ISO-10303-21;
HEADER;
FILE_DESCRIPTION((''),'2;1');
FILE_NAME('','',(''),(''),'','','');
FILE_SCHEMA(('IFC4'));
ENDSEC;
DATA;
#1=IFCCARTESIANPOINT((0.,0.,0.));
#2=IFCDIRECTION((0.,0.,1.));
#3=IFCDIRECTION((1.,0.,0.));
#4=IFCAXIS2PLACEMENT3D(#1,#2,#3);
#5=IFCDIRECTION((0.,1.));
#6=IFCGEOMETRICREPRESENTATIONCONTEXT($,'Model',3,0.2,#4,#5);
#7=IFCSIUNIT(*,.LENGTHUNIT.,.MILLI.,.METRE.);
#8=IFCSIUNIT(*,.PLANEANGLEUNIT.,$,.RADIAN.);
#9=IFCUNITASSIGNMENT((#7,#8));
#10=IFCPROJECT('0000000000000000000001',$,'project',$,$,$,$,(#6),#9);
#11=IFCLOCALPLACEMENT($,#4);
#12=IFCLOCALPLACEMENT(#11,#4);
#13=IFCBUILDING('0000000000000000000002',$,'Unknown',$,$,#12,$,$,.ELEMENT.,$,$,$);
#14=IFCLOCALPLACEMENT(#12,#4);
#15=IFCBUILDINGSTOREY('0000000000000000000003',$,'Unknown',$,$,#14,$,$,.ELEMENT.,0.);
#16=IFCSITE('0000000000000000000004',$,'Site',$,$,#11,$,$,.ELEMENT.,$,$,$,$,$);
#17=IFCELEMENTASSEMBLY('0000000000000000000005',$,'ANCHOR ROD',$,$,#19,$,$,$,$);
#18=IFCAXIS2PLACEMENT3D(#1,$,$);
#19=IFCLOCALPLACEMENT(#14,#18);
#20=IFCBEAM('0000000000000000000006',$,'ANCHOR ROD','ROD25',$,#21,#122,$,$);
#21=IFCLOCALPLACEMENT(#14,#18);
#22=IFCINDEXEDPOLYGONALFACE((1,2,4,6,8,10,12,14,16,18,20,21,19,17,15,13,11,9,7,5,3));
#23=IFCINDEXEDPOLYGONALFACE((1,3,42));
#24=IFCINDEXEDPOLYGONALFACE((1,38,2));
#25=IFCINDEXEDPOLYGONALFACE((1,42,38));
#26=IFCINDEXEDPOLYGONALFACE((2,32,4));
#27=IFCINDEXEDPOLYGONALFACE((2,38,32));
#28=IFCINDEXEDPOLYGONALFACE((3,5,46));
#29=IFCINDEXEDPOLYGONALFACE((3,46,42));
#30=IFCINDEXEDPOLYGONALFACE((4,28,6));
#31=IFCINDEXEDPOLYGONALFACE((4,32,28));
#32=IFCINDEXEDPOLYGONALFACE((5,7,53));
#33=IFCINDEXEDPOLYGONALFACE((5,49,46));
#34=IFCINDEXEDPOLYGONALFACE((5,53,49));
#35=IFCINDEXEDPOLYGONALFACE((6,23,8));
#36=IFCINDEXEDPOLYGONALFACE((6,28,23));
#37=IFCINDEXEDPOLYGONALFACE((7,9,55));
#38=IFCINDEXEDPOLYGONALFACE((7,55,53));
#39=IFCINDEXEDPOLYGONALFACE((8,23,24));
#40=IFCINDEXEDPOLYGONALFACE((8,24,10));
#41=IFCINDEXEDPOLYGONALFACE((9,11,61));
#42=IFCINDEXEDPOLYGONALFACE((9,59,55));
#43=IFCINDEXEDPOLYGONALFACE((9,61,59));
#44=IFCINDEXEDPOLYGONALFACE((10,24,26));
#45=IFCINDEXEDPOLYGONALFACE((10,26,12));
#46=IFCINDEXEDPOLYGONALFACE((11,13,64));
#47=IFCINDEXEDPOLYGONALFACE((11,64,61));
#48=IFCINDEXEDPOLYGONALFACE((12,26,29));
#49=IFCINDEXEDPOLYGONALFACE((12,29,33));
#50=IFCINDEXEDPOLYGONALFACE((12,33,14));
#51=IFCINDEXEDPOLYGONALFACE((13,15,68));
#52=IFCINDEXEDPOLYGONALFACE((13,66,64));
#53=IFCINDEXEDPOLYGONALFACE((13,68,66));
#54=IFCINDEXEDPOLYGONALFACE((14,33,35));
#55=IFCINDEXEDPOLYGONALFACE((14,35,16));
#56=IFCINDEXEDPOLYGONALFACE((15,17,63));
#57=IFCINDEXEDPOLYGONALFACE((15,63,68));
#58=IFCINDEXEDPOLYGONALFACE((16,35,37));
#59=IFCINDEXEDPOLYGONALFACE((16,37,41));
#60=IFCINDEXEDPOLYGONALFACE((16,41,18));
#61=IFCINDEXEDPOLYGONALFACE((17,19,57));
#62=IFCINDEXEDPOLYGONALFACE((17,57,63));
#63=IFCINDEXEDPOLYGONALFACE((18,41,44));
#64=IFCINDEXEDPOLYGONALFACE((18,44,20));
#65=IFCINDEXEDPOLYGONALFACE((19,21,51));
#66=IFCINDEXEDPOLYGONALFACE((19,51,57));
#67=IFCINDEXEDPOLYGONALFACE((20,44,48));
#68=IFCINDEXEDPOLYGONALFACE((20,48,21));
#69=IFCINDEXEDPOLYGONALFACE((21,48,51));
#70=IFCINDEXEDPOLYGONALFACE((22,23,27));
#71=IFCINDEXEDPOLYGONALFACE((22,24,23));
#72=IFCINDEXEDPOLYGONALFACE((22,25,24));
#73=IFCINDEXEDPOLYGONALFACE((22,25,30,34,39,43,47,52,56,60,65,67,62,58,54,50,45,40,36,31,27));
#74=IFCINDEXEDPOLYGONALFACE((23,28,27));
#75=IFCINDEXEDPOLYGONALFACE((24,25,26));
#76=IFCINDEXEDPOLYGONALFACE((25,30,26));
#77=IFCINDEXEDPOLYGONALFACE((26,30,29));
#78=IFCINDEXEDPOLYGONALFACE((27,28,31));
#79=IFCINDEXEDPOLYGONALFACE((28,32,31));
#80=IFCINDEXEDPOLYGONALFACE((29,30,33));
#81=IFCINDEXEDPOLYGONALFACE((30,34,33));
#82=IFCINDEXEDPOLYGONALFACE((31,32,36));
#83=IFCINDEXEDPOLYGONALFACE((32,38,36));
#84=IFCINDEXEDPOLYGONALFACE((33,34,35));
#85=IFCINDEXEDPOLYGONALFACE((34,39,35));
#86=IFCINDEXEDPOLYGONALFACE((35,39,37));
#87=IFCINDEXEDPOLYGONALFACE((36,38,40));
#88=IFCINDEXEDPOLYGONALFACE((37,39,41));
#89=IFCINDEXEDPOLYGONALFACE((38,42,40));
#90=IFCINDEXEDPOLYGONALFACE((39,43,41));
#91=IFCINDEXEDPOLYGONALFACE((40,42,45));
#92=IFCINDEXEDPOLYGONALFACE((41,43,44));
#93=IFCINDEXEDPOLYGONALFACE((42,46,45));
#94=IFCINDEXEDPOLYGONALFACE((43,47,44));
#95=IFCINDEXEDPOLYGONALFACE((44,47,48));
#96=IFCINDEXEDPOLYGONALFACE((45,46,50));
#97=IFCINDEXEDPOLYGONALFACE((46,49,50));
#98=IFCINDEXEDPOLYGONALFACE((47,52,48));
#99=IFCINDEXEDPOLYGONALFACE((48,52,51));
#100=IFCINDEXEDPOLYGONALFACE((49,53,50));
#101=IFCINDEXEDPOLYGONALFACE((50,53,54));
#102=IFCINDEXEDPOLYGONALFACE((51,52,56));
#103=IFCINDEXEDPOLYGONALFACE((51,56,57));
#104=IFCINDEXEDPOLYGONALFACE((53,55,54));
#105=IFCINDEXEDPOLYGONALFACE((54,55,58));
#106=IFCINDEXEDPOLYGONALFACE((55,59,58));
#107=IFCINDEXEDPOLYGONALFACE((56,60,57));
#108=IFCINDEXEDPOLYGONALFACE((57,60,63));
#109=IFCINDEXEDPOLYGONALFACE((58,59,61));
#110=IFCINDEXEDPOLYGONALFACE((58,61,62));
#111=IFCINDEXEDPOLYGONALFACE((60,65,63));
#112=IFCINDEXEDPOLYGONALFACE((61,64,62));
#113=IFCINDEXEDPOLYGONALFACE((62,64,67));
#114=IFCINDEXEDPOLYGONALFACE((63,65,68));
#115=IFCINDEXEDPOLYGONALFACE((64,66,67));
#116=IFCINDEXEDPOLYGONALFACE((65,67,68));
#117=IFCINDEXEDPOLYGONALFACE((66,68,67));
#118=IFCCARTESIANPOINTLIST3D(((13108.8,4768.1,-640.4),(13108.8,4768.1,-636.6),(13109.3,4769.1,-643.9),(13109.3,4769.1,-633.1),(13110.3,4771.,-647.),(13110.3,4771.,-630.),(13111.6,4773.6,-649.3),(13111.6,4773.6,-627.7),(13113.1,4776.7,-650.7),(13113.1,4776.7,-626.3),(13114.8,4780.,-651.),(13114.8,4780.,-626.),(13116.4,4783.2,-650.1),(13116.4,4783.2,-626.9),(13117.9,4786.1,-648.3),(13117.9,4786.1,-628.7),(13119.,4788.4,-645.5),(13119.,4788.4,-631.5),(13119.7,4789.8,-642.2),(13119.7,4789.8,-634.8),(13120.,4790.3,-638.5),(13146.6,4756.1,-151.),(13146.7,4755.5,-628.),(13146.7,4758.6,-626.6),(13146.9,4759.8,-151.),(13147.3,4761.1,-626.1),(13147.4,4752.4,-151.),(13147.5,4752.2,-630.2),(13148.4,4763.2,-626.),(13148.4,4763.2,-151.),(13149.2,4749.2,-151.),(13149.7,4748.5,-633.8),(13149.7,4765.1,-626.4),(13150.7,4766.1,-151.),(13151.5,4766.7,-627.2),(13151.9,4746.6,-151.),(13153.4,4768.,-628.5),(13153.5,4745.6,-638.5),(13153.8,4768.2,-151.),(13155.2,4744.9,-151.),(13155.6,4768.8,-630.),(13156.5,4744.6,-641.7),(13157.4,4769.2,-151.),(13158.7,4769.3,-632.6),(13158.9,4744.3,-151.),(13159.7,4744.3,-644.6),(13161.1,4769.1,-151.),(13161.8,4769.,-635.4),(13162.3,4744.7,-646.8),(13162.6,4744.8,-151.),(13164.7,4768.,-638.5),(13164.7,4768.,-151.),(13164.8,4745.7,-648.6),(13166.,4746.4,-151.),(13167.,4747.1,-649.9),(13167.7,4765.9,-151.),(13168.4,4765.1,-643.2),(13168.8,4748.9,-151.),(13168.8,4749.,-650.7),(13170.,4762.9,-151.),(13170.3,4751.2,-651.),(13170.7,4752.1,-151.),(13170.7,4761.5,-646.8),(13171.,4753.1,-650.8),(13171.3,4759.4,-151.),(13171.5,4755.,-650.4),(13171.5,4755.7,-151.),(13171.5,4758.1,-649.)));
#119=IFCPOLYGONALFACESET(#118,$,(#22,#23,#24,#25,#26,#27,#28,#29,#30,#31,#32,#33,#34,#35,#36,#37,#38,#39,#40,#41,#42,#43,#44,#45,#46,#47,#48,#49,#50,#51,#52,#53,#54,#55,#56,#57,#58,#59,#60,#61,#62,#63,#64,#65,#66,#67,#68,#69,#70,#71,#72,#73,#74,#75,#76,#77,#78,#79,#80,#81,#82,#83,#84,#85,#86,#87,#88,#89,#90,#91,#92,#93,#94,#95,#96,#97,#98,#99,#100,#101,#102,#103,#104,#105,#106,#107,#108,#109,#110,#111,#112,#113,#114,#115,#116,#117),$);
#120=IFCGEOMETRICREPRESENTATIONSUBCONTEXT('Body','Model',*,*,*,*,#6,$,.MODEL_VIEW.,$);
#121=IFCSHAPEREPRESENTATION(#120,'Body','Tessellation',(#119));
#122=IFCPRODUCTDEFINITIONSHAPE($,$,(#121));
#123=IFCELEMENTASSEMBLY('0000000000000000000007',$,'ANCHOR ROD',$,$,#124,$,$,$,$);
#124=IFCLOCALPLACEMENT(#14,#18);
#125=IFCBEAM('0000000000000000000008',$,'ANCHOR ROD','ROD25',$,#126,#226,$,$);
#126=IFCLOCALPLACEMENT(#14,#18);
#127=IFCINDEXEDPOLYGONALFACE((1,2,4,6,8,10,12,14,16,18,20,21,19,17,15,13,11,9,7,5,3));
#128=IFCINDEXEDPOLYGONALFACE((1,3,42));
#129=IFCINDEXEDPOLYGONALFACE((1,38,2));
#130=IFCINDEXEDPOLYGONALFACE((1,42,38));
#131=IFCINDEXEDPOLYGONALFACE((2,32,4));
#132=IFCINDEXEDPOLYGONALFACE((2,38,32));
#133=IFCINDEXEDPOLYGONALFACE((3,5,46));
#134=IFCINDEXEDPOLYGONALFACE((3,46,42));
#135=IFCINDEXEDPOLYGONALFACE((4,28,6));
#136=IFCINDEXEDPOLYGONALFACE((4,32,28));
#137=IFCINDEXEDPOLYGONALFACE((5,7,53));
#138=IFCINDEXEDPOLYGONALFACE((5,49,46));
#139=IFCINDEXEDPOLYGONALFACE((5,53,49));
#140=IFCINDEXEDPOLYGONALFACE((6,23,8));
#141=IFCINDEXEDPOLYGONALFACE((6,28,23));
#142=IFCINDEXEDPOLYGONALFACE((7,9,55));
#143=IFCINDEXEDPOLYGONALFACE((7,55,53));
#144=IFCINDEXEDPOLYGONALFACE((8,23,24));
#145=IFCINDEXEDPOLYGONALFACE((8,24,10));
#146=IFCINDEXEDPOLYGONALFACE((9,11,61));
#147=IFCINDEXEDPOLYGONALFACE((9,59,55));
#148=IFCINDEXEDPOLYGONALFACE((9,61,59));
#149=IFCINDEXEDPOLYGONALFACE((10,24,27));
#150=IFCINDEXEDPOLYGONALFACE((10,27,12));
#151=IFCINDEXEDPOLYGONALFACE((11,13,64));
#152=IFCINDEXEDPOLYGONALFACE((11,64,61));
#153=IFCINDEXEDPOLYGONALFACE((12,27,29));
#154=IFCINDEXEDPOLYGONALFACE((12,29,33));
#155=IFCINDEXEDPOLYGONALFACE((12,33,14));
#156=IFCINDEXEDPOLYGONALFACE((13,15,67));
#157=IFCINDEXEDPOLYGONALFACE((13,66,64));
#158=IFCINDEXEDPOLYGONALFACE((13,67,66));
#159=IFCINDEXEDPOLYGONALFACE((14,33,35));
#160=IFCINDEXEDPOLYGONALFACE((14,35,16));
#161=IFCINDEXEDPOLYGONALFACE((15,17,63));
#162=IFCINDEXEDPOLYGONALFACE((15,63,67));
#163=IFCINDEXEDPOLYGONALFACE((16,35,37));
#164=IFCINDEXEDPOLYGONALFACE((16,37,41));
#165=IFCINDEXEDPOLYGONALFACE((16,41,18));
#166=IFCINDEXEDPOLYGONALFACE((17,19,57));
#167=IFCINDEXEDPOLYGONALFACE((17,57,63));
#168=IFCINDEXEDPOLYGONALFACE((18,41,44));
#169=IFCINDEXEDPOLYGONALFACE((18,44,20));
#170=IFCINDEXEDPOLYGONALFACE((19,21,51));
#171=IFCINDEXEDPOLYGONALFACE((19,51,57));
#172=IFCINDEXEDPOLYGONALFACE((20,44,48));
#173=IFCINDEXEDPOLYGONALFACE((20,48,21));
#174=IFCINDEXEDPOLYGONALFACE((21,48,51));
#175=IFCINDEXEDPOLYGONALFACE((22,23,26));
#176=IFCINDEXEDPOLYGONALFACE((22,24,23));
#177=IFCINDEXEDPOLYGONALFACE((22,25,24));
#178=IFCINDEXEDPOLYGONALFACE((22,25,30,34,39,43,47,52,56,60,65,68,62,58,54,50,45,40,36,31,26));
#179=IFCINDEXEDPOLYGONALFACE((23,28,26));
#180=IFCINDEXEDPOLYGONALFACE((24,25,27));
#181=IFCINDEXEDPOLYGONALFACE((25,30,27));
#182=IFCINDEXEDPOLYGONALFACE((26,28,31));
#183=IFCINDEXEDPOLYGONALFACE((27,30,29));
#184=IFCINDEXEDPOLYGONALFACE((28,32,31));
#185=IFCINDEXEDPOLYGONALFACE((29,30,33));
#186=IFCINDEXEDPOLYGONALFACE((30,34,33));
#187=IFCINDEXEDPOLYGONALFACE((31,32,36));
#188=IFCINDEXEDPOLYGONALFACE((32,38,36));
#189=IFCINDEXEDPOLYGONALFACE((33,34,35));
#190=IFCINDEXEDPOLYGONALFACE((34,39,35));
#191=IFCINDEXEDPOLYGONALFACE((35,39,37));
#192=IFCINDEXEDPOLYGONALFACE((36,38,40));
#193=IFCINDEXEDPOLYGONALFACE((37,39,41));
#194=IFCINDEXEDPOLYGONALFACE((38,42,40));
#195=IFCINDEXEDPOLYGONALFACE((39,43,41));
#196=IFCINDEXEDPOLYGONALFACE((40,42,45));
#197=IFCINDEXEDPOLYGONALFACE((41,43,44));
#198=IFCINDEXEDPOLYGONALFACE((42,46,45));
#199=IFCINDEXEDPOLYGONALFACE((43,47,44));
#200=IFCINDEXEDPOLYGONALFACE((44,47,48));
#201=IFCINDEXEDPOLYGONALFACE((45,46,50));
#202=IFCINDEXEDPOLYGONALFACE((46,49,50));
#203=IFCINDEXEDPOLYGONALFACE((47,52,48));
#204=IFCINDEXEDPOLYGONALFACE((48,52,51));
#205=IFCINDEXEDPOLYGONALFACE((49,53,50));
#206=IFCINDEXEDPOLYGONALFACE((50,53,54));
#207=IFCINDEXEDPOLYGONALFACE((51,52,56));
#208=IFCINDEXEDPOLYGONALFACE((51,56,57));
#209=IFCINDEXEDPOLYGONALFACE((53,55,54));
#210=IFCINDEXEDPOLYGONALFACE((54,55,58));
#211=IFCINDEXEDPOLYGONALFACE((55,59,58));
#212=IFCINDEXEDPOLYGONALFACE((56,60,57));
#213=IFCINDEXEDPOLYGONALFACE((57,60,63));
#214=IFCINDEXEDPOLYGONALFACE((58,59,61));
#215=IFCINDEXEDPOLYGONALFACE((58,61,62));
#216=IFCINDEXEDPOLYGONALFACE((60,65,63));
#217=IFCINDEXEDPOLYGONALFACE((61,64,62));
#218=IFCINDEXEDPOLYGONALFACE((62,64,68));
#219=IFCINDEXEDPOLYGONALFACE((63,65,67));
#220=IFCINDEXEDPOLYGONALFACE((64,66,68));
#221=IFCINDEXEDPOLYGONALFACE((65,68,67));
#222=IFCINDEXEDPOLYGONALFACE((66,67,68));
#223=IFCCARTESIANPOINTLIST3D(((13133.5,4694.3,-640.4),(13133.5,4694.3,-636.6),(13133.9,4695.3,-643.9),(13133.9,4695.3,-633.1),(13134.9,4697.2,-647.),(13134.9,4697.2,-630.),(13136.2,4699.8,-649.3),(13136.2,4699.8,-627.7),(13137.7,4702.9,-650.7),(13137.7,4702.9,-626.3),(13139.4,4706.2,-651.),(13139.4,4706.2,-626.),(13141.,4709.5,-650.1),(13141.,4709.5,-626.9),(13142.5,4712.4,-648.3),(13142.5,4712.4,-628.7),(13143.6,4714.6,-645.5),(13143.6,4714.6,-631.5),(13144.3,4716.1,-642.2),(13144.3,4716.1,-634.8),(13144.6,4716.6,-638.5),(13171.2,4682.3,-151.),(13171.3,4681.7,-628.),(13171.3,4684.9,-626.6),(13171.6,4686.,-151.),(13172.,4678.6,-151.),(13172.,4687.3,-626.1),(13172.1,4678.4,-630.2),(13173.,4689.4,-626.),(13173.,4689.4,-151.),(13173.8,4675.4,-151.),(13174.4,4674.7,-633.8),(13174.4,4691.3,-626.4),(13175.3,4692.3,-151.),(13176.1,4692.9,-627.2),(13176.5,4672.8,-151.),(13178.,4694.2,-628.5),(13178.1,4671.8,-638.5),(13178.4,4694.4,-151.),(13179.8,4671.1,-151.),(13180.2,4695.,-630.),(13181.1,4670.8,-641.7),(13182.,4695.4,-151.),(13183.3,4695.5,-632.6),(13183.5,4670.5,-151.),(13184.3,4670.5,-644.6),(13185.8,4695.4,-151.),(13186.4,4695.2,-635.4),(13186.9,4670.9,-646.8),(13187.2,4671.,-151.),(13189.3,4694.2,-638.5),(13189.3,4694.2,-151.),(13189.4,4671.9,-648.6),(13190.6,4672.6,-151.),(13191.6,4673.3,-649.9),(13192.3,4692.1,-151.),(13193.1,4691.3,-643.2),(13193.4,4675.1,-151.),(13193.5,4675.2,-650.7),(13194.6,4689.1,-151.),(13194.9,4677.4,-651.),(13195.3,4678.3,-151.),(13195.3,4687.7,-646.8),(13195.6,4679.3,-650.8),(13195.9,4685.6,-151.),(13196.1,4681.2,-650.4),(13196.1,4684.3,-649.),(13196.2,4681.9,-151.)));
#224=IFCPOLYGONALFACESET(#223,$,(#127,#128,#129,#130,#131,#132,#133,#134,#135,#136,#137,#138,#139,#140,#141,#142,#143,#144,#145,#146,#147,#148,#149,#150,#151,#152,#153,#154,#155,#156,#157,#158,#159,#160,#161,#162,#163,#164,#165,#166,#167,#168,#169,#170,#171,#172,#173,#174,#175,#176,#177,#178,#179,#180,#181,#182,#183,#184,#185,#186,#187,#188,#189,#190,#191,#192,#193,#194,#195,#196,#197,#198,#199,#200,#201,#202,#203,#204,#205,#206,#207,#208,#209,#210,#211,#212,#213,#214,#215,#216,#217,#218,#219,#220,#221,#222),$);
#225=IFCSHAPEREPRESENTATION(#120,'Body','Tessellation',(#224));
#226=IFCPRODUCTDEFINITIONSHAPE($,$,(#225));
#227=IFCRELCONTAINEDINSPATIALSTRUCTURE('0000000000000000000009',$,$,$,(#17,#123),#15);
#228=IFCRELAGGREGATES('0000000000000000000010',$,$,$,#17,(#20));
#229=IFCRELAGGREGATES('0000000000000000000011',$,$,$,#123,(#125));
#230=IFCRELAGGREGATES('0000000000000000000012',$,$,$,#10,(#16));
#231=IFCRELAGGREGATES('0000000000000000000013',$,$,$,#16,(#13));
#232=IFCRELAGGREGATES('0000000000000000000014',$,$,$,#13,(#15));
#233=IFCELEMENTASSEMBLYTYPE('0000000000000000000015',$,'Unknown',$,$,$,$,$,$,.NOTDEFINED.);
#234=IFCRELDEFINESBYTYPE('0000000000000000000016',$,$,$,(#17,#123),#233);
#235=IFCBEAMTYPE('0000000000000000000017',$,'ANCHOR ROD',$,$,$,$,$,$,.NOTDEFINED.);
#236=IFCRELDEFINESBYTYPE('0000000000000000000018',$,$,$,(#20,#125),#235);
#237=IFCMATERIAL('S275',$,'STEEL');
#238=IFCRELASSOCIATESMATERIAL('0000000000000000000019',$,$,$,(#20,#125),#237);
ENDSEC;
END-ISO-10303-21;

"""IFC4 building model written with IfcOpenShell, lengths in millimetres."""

from ifc_helpers import new_model, entity, si_unit, direction, frame, origin_with_axes, place, context, subcontext, project, spatial, material, type_object, element, aggregate, save


model = new_model("IFC4")

# Units and contexts
model_context = context("Model", 3, precision=0.2, world=origin_with_axes(), true_north=direction((0.0, 1.0)))
body_context = subcontext(model_context, "Body", "Model", "MODEL_VIEW")
ifc_project = project(units=[si_unit("LENGTHUNIT", "METRE", prefix="MILLI"), si_unit("PLANEANGLEUNIT", "RADIAN")], contexts=[model_context])

# Site, building, storey
site_placement = place(None, origin_with_axes())
site = spatial("IfcSite", under=ifc_project, at=site_placement, Name="Site", CompositionType="ELEMENT")
building_placement = place(site_placement, origin_with_axes())
building = spatial("IfcBuilding", under=site, at=building_placement, Name="Unknown", CompositionType="ELEMENT")
storey_placement = place(building_placement, origin_with_axes())
storey = spatial("IfcBuildingStorey", under=building, at=storey_placement, Name="Unknown", CompositionType="ELEMENT", Elevation=0.0)

# Element assemblies, beams
element_assembly_type = type_object("IfcElementAssemblyType", Name="Unknown", PredefinedType="NOTDEFINED")
ifc_material_1 = material(Name="S275", Category="STEEL")
beam_type_1 = type_object("IfcBeamType", Name="ANCHOR ROD", PredefinedType="NOTDEFINED")
assembly_1_placement = place(storey_placement, frame((13159.1, 4756.8, -151.0), z_axis=(0.447007, 0.894531, 0.0), x_axis=(0.0, 0.0, -1.0)))
assembly_1 = element("IfcElementAssembly", 1, at=assembly_1_placement, inside=storey, type_object=element_assembly_type, Name="ANCHOR ROD")
beam_1_placement = place(assembly_1_placement, origin_with_axes())
beam_1 = element("IfcBeam", 2, at=beam_1_placement, type_object=beam_type_1, material=ifc_material_1, Name="ANCHOR ROD", Description="ROD25", context=body_context, shape_type="SolidModel", body=[
    entity("IfcSweptDiskSolid", entity("IfcIndexedPolyCurve", entity("IfcCartesianPointList3D", [[0.0, 0.0, 0.0], [487.5, 0.0, 0.0], [487.5, 50.0, 0.0]]), [entity("IfcLineIndex", [1, 2, 3])]), 12.5),
])
assembly_2_placement = place(storey_placement, frame((13183.7, 4683.0, -151.0), z_axis=(0.447007, 0.894531, 0.0), x_axis=(0.0, 0.0, -1.0)))
assembly_2 = element("IfcElementAssembly", 3, at=assembly_2_placement, inside=storey, type_object=element_assembly_type, Name="ANCHOR ROD")
beam_2_placement = place(assembly_2_placement, origin_with_axes())
beam_2 = element("IfcBeam", 4, at=beam_2_placement, type_object=beam_type_1, material=ifc_material_1, Name="ANCHOR ROD", Description="ROD25", context=body_context, shape_type="SolidModel", body=[
    entity("IfcSweptDiskSolid", entity("IfcIndexedPolyCurve", entity("IfcCartesianPointList3D", [[0.0, 0.0, 0.0], [487.5, 0.0, 0.0], [487.5, 50.0, 0.0]]), [entity("IfcLineIndex", [1, 2, 3])]), 12.5),
])

aggregate(assembly_1, [beam_1])
aggregate(assembly_2, [beam_2])

save(model, "model.ifc")
